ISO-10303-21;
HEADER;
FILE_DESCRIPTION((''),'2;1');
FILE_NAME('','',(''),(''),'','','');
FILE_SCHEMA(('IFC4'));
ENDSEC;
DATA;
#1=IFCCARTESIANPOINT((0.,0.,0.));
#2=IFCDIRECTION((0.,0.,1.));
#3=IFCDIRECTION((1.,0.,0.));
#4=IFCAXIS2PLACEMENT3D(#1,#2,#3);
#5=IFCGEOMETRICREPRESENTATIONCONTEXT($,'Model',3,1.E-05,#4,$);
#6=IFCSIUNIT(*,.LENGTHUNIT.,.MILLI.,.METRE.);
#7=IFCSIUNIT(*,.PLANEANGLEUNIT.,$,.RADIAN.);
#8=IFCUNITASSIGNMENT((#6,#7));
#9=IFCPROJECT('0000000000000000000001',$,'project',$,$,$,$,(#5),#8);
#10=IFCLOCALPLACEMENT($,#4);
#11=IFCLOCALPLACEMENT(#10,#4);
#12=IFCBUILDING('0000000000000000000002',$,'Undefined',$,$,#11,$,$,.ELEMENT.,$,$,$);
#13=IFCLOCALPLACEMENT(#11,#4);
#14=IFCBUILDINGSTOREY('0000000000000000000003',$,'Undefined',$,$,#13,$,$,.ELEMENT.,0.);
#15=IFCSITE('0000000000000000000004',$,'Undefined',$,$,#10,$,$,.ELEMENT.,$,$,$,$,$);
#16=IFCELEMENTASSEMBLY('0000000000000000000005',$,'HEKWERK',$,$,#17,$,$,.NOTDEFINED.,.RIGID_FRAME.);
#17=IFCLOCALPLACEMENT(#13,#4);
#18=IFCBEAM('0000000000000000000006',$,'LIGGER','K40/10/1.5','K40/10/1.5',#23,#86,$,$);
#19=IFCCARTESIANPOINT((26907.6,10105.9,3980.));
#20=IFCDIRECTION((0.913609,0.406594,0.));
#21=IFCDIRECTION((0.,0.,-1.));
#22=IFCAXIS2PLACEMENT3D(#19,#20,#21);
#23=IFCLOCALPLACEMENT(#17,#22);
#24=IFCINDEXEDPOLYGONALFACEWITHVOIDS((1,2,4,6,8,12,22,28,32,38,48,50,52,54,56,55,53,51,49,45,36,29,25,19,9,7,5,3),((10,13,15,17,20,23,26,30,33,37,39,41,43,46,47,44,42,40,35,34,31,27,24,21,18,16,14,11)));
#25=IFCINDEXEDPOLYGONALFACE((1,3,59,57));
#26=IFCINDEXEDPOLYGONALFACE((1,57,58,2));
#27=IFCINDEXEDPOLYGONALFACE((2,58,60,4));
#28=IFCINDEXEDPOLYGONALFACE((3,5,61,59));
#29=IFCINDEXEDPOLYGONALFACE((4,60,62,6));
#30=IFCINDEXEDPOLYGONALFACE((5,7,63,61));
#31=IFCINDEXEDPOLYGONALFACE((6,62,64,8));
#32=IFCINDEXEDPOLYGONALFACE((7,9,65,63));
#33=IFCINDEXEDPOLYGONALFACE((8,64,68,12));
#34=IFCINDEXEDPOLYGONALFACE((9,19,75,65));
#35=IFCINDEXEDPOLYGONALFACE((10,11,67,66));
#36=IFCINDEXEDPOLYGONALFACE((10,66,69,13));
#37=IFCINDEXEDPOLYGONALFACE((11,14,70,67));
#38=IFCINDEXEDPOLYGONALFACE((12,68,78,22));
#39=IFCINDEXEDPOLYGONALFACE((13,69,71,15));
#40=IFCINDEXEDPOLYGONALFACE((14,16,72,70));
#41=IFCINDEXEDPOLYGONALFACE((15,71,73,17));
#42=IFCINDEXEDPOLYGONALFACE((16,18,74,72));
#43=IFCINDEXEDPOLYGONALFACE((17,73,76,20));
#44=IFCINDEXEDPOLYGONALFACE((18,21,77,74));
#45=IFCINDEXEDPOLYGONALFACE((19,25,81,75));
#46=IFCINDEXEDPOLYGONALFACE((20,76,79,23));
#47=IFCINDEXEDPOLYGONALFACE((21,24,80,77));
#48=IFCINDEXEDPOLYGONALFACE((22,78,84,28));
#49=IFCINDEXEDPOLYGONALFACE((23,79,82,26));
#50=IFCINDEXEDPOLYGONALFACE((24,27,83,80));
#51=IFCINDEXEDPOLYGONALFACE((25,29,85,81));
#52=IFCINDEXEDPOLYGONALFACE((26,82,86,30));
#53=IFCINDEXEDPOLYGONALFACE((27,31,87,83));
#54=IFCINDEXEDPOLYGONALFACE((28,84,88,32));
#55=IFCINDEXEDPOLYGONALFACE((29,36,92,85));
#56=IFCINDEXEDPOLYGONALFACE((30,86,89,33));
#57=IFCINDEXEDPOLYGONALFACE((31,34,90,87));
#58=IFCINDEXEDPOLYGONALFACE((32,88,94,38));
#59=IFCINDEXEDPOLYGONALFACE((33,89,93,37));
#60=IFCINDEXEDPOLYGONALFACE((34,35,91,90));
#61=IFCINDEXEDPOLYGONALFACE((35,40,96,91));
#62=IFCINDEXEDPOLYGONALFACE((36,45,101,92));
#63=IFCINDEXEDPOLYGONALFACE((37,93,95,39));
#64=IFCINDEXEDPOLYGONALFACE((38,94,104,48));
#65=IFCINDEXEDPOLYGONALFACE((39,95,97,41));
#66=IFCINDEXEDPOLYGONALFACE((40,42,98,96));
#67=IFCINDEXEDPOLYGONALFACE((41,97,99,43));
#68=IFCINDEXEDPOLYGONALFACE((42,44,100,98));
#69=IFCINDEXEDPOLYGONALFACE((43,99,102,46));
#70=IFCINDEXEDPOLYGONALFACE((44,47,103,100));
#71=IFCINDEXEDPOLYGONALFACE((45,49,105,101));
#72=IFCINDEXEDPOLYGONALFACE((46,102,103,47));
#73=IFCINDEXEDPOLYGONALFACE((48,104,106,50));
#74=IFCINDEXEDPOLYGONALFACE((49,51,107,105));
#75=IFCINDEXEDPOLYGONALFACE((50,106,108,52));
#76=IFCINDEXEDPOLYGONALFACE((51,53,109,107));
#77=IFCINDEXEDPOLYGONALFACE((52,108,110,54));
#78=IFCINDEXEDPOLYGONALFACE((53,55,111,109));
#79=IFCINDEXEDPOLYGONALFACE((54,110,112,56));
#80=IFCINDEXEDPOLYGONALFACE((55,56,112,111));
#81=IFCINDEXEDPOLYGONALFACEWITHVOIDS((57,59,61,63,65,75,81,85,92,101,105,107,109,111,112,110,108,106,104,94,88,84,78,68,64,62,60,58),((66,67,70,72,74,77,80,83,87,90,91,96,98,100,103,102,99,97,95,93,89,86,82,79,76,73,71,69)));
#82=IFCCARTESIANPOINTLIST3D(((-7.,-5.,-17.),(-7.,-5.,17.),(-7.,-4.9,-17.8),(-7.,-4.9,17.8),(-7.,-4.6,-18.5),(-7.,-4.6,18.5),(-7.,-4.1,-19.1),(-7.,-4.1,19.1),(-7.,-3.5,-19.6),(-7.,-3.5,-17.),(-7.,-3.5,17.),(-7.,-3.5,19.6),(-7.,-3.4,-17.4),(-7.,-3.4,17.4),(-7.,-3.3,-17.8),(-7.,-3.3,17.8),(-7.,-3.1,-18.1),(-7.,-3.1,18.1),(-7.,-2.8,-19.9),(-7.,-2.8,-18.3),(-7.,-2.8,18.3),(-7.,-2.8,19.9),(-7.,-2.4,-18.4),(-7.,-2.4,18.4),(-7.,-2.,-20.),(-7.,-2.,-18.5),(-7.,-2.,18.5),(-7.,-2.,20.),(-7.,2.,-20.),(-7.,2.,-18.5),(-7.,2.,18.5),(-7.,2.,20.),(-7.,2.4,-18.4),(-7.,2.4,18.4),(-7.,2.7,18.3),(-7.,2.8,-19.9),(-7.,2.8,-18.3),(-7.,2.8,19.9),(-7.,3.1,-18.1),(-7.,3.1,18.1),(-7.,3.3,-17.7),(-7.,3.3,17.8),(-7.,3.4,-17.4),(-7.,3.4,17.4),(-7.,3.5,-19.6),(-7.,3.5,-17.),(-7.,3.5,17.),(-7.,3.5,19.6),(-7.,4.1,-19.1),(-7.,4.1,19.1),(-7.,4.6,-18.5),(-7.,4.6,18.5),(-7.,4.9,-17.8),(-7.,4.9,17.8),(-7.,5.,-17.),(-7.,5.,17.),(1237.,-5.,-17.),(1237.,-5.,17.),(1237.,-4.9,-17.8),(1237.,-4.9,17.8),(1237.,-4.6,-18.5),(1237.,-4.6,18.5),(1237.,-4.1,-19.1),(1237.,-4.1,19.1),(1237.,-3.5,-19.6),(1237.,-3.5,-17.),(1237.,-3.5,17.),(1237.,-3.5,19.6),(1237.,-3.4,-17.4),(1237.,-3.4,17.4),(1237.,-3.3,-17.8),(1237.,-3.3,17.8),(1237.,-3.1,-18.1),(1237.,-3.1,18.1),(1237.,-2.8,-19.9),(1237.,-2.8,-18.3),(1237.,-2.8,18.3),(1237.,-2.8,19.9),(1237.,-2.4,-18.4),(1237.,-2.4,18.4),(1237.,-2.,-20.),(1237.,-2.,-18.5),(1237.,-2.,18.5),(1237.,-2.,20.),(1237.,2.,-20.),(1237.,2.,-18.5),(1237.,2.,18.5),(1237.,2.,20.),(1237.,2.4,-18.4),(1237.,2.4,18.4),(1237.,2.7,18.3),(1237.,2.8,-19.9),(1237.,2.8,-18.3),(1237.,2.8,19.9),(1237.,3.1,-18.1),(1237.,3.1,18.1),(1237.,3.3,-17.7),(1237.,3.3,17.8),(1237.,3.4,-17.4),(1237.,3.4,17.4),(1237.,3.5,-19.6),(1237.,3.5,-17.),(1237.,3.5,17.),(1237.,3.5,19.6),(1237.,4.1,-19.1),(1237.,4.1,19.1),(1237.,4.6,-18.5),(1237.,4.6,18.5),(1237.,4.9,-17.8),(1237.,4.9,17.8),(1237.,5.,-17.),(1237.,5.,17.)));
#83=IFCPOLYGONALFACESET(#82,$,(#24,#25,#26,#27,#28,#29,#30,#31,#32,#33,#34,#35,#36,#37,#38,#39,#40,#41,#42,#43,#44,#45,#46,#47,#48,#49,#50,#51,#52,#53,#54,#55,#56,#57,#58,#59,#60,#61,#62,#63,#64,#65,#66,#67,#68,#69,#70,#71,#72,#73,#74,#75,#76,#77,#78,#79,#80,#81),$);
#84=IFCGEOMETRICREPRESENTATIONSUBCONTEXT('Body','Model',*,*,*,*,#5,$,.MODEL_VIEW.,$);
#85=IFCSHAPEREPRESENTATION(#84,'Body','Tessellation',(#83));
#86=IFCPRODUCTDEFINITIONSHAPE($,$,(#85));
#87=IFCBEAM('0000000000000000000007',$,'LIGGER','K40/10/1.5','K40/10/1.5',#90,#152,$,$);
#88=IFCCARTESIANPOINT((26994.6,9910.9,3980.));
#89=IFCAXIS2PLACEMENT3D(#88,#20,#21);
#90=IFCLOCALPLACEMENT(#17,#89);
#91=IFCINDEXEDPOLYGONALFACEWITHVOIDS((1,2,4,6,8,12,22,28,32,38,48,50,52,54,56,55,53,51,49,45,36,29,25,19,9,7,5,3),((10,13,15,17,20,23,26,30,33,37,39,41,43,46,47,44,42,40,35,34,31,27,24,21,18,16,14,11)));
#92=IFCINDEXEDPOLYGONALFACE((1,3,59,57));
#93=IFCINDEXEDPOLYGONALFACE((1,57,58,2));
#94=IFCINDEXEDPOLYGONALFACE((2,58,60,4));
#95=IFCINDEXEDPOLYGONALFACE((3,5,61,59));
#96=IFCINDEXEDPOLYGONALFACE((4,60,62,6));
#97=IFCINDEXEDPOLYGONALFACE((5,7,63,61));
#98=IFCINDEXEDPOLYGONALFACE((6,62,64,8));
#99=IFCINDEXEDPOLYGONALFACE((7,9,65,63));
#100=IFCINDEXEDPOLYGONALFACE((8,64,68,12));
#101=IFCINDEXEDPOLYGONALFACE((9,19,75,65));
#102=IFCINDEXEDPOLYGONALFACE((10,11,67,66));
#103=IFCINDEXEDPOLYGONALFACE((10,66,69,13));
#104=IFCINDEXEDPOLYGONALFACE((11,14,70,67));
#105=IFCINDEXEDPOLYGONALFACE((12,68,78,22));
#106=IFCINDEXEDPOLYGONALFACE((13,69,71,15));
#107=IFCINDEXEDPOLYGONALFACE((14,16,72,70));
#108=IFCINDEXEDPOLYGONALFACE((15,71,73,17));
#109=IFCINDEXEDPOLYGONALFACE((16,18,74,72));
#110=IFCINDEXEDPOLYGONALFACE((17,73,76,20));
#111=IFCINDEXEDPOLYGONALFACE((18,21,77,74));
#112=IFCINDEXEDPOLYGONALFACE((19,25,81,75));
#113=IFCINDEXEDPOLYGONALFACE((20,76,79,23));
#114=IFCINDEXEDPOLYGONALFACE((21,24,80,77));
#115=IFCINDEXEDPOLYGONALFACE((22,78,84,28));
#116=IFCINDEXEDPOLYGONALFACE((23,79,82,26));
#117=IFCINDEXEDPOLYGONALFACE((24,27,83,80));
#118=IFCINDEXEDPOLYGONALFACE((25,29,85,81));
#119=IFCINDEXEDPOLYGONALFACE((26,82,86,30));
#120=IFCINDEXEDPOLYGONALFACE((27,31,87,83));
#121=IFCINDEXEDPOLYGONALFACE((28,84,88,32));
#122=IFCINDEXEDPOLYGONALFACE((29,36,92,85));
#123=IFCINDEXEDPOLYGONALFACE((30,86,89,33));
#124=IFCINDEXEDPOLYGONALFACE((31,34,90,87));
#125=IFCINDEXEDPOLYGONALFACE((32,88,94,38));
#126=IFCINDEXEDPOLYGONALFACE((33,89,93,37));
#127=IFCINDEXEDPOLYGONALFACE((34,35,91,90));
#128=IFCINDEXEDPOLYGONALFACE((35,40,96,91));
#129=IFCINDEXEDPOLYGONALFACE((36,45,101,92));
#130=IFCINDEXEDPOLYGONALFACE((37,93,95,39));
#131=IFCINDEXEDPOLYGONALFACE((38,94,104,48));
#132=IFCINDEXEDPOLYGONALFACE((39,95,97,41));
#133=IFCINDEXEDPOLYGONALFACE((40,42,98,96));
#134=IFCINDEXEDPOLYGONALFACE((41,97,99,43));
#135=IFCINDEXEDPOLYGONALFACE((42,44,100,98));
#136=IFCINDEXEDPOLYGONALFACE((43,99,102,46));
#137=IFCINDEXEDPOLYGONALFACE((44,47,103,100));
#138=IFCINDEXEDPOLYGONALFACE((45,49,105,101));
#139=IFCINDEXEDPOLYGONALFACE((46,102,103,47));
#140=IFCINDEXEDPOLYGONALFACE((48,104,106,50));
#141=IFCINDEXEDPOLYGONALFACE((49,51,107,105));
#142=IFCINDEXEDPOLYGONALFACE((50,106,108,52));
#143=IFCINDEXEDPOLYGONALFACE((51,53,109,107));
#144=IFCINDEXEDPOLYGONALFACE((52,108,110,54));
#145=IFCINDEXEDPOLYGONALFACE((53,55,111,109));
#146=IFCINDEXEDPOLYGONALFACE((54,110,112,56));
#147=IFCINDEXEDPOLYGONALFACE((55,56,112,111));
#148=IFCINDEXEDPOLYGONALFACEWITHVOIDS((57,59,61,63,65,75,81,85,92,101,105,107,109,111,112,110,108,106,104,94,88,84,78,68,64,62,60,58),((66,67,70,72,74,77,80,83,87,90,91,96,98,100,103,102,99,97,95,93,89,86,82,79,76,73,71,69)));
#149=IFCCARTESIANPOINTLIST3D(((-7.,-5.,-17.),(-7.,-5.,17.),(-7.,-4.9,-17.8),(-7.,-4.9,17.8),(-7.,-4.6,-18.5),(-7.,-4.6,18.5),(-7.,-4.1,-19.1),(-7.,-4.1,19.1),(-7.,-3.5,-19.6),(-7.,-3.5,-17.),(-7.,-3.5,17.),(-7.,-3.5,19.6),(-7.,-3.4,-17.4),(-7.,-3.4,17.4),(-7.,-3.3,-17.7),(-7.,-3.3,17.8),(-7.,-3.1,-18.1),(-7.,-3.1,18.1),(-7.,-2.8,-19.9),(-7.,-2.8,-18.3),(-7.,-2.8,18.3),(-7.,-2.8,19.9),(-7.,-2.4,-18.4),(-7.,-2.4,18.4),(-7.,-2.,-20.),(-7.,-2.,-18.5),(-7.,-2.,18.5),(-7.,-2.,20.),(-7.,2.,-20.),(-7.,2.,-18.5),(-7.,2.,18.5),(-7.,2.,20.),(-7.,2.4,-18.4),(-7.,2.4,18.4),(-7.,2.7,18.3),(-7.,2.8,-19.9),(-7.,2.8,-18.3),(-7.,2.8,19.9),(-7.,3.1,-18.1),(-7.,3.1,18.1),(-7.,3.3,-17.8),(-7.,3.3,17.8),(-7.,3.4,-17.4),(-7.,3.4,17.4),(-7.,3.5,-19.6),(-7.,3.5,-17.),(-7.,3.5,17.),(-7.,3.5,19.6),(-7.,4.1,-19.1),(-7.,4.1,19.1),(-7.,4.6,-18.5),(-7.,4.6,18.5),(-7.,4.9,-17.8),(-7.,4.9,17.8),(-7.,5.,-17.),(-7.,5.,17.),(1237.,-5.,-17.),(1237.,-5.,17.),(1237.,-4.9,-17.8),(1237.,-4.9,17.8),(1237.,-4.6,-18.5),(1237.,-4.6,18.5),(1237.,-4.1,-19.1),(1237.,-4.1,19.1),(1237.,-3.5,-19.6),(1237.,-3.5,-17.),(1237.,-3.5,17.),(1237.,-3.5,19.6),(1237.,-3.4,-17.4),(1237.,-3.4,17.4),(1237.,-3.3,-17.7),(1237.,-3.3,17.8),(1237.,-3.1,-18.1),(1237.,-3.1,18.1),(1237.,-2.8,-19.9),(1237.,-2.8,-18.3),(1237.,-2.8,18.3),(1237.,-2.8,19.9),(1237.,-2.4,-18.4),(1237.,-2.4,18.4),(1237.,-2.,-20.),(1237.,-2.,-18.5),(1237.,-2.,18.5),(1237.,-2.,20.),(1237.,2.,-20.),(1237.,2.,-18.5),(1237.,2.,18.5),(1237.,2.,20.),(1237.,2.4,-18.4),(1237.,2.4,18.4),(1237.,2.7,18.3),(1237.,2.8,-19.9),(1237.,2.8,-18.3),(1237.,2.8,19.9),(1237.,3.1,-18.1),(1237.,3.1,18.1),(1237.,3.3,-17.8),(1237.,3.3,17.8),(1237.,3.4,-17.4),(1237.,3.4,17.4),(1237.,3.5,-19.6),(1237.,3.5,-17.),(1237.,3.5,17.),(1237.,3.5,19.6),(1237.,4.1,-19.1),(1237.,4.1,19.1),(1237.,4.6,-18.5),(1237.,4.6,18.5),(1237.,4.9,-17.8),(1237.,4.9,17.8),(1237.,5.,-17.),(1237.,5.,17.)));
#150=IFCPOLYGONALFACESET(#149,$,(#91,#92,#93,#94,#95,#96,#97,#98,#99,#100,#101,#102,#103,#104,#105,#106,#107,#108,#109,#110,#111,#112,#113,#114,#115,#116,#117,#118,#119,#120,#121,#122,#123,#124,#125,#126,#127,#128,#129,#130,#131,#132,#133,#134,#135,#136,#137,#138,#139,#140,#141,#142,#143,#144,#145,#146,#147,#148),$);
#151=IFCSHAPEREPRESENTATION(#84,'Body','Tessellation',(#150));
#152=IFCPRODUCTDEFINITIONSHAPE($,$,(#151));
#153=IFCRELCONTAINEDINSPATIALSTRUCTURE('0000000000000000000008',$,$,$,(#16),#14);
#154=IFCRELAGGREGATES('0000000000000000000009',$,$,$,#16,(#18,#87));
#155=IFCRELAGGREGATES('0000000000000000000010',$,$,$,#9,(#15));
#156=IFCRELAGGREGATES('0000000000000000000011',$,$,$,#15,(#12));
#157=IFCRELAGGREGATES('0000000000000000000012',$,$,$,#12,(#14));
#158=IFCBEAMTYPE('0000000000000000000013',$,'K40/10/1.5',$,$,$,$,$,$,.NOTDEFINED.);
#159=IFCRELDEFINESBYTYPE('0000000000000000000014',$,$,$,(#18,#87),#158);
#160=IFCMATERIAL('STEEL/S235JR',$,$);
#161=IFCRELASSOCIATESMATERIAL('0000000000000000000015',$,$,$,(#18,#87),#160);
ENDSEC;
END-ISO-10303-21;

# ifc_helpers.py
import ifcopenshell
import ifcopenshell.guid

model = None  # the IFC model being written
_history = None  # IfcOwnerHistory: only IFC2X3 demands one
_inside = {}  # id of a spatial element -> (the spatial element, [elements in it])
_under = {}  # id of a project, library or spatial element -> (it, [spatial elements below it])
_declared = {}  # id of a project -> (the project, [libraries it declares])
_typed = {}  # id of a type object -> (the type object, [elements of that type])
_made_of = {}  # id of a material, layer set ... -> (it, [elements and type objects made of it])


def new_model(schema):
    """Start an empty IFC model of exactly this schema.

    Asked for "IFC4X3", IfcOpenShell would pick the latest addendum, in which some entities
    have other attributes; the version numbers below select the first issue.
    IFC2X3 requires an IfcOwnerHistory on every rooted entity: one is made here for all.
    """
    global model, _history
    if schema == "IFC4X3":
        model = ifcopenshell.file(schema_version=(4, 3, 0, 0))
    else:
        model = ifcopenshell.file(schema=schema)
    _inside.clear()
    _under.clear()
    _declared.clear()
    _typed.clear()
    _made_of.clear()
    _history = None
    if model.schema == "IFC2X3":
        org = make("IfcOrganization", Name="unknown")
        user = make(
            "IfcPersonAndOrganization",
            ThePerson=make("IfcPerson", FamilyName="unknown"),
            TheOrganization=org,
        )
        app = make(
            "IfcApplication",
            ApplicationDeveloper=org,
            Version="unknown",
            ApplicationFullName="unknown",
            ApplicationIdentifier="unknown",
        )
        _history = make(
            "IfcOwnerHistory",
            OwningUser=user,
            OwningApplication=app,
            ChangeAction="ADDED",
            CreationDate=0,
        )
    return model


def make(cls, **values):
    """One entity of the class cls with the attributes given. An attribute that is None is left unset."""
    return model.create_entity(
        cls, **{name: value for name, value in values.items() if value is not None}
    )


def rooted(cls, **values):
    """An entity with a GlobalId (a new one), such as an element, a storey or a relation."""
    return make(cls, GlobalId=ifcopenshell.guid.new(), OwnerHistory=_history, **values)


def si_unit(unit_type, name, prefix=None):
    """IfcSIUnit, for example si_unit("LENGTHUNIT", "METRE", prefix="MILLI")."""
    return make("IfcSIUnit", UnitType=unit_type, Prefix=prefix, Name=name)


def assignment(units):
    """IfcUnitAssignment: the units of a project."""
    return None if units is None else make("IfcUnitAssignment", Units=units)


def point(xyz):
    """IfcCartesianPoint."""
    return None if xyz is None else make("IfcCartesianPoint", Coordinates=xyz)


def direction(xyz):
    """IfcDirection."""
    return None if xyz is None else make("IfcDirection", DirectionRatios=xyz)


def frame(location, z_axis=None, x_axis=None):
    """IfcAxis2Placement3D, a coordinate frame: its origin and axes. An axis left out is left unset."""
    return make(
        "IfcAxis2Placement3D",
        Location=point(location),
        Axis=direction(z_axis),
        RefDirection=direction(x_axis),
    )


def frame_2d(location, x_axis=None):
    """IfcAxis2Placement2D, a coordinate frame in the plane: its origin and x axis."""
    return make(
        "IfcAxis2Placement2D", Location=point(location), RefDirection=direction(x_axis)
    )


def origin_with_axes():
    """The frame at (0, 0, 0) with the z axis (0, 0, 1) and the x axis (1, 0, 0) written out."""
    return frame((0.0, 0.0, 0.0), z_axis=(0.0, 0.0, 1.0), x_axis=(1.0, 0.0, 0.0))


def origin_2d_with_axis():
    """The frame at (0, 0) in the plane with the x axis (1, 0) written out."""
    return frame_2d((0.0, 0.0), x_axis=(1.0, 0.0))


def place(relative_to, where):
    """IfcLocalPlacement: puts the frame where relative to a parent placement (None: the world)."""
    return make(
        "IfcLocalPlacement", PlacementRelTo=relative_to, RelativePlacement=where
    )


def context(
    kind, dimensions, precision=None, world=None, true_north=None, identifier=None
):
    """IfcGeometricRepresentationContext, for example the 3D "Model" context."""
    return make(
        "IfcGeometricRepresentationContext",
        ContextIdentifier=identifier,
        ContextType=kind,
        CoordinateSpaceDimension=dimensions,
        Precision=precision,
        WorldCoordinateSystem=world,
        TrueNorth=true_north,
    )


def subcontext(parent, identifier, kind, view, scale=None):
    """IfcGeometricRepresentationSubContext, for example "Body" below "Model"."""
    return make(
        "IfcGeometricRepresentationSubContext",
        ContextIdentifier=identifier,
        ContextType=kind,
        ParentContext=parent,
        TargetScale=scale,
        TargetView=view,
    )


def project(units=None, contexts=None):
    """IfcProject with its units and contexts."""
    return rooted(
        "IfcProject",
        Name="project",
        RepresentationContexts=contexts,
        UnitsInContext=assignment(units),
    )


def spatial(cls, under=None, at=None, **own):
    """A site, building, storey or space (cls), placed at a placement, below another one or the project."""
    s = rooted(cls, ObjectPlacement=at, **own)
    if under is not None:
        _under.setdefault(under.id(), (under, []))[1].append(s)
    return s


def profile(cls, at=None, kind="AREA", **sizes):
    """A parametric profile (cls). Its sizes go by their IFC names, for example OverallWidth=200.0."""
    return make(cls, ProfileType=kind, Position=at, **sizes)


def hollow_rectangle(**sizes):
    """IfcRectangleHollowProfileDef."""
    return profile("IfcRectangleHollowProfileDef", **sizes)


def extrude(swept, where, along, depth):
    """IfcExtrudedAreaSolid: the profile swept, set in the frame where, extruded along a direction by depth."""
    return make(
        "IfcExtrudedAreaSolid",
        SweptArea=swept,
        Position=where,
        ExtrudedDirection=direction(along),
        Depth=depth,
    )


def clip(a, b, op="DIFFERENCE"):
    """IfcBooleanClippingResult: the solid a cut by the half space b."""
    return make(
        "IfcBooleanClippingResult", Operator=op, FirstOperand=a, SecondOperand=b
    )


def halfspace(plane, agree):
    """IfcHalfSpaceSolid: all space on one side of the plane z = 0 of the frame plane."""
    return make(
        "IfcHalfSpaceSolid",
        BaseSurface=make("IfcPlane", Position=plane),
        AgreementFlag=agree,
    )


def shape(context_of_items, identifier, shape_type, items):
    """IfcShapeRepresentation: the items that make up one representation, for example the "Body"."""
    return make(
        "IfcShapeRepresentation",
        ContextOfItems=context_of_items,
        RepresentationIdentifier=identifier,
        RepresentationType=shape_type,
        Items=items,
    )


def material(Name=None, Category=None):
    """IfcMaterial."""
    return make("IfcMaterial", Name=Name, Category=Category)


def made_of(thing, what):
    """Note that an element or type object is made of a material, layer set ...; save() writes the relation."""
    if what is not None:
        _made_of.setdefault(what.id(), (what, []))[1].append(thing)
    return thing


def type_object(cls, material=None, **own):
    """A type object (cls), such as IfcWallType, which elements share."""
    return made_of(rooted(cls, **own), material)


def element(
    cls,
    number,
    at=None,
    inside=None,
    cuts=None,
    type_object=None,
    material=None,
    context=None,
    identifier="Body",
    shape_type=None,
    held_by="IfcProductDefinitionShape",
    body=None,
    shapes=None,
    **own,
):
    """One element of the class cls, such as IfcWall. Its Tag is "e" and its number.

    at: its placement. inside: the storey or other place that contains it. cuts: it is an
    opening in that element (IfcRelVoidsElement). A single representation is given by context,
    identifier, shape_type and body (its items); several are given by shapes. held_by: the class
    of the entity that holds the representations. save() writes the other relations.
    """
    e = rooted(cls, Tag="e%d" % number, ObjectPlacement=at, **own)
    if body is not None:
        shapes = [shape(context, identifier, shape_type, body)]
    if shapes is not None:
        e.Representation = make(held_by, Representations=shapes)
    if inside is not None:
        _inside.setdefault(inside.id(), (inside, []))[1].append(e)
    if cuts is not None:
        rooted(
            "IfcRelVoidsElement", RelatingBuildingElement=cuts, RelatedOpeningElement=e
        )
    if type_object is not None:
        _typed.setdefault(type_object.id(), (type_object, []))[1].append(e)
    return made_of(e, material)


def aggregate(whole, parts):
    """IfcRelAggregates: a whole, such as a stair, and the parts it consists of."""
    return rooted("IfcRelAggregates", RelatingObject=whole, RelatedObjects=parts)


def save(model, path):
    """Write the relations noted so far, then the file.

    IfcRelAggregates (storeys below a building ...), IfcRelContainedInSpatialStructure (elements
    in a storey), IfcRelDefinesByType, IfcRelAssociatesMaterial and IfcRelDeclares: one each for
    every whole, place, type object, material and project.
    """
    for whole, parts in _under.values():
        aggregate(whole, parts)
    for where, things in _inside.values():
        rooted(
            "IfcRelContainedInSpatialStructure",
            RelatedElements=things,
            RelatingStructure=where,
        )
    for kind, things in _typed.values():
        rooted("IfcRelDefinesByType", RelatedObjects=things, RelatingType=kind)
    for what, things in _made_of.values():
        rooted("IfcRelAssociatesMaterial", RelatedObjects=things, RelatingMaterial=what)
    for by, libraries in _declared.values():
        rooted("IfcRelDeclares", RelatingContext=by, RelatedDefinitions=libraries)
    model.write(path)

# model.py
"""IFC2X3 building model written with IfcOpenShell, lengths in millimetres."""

from ifc_helpers import new_model, si_unit, frame, origin_with_axes, origin_2d_with_axis, place, context, subcontext, project, spatial, hollow_rectangle, extrude, clip, halfspace, material, type_object, element, aggregate, save


model = new_model("IFC2X3")

# Units and contexts
model_context = context("Model", 3, precision=1e-05, world=origin_with_axes())
body_context = subcontext(model_context, "Body", "Model", "MODEL_VIEW")
ifc_project = project(units=[si_unit("LENGTHUNIT", "METRE", prefix="MILLI"), si_unit("PLANEANGLEUNIT", "RADIAN")], contexts=[model_context])

# Site, building, storey
site_placement = place(None, origin_with_axes())
site = spatial("IfcSite", under=ifc_project, at=site_placement, Name="Undefined", CompositionType="ELEMENT")
building_placement = place(site_placement, origin_with_axes())
building = spatial("IfcBuilding", under=site, at=building_placement, Name="Undefined", CompositionType="ELEMENT")
storey_placement = place(building_placement, origin_with_axes())
storey = spatial("IfcBuildingStorey", under=building, at=storey_placement, Name="Undefined", CompositionType="ELEMENT", Elevation=0.0)

# Element assembly
assembly_1_placement = place(storey_placement, origin_with_axes())
assembly_1 = element("IfcElementAssembly", 1, at=assembly_1_placement, inside=storey, Name="HEKWERK", AssemblyPlace="NOTDEFINED", PredefinedType="RIGID_FRAME")
ifc_material_1 = material(Name="STEEL/S235JR")
beam_type_1 = type_object("IfcBeamType", Name="K40/10/1.5", PredefinedType="NOTDEFINED")

# Beams
beam_1_placement = place(assembly_1_placement, frame((26907.6, 10105.9, 3980.0), z_axis=(0.913609, 0.406594, 0.0), x_axis=(0.0, 0.0, -1.0)))
beam_1 = element("IfcBeam", 2, at=beam_1_placement, type_object=beam_type_1, material=ifc_material_1, Name="LIGGER", Description="K40/10/1.5", ObjectType="K40/10/1.5", context=body_context, shape_type="Clipping", body=[
    clip(clip(extrude(hollow_rectangle(XDim=10.0, YDim=40.0, WallThickness=1.5, InnerFilletRadius=1.5, OuterFilletRadius=3.0, at=origin_2d_with_axis()), frame((1237.0, 0.0, 0.0), z_axis=(-1.0, 0.0, 0.0), x_axis=(0.0, -1.0, 0.0)), (0.0, 0.0, 1.0), 1244.0), halfspace(frame((1237.0, -56.4, -3.2), z_axis=(1.0, 0.0, 0.0), x_axis=(0.0, -0.057802, -0.998328)), False)), halfspace(frame((-7.0, 56.4, -3.2), z_axis=(-1.0, 0.0, 0.0), x_axis=(0.0, 0.057802, -0.998328)), False)),
])
beam_2_placement = place(assembly_1_placement, frame((26994.6, 9910.9, 3980.0), z_axis=(0.913609, 0.406594, 0.0), x_axis=(0.0, 0.0, -1.0)))
beam_2 = element("IfcBeam", 3, at=beam_2_placement, type_object=beam_type_1, material=ifc_material_1, Name="LIGGER", Description="K40/10/1.5", ObjectType="K40/10/1.5", context=body_context, shape_type="Clipping", body=[
    clip(clip(extrude(hollow_rectangle(XDim=10.0, YDim=40.0, WallThickness=1.5, InnerFilletRadius=1.5, OuterFilletRadius=3.0, at=origin_2d_with_axis()), frame((1237.0, 0.0, 0.0), z_axis=(-1.0, 0.0, 0.0), x_axis=(0.0, -1.0, 0.0)), (0.0, 0.0, 1.0), 1244.0), halfspace(frame((1237.0, -56.4, -3.2), z_axis=(1.0, 0.0, 0.0), x_axis=(0.0, -0.057802, -0.998328)), False)), halfspace(frame((-7.0, 56.4, -3.2), z_axis=(-1.0, 0.0, 0.0), x_axis=(0.0, 0.057802, -0.998328)), False)),
])

aggregate(assembly_1, [beam_1, beam_2])

save(model, "model.ifc")
